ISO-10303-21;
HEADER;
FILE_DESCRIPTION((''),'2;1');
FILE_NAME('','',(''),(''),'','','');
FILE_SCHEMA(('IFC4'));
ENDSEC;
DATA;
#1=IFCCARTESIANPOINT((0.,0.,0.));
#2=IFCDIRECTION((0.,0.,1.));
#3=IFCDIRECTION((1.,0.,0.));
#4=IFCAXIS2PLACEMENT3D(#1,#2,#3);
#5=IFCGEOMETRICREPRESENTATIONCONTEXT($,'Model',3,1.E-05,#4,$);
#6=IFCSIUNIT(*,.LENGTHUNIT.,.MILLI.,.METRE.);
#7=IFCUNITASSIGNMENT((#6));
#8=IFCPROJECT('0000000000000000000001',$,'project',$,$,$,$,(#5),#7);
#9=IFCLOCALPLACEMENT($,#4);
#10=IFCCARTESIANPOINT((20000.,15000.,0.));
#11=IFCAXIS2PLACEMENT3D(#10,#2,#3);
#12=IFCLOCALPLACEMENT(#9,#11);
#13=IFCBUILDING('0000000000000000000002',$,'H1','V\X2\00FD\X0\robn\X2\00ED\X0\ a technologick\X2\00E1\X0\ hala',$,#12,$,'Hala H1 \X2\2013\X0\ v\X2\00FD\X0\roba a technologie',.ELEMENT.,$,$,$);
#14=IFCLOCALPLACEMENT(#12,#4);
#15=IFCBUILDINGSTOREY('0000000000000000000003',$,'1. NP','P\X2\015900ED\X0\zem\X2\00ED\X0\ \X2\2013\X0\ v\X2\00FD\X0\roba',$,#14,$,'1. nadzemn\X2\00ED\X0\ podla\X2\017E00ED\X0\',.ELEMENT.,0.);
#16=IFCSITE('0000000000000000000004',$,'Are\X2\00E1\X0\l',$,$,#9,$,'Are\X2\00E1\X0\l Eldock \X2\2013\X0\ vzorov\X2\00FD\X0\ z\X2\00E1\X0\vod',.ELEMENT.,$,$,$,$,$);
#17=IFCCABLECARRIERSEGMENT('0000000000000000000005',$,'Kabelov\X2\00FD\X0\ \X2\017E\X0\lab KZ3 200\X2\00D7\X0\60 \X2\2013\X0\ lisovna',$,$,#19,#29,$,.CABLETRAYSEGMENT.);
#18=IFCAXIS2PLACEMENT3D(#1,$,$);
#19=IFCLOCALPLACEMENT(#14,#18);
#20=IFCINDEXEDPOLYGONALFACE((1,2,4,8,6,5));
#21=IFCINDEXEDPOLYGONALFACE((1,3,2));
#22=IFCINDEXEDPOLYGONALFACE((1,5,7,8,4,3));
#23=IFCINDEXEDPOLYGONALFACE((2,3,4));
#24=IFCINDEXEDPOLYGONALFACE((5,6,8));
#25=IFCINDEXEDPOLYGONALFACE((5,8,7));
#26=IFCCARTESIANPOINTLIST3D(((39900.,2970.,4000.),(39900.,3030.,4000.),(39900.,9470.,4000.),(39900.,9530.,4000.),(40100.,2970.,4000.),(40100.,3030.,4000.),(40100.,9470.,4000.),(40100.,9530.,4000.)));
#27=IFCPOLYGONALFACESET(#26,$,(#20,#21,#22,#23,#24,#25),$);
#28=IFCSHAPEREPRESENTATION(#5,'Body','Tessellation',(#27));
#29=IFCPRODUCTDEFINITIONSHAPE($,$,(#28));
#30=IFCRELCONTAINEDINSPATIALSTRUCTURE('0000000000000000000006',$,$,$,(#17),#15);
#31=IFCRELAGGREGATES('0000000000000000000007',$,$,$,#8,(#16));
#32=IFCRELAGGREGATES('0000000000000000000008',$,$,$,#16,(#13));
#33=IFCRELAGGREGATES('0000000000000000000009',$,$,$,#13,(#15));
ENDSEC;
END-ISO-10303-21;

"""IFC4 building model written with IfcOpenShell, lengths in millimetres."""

from ifc_helpers import new_model, si_unit, frame, origin_with_axes, origin_2d, place, context, project, spatial, rectangle, extrude, element, save


model = new_model("IFC4")

# Units and contexts
model_context = context("Model", 3, precision=1e-05, world=origin_with_axes())
ifc_project = project(units=[si_unit("LENGTHUNIT", "METRE", prefix="MILLI")], contexts=[model_context])

# Site, building, storey
site_placement = place(None, origin_with_axes())
site = spatial("IfcSite", under=ifc_project, at=site_placement, Name="Areál", LongName="Areál Eldock – vzorový závod", CompositionType="ELEMENT")
building_placement = place(site_placement, frame((20000.0, 15000.0, 0.0), z_axis=(0.0, 0.0, 1.0), x_axis=(1.0, 0.0, 0.0)))
building = spatial("IfcBuilding", under=site, at=building_placement, Name="H1", Description="Výrobní a technologická hala", LongName="Hala H1 – výroba a technologie", CompositionType="ELEMENT")
storey_placement = place(building_placement, origin_with_axes())
storey = spatial("IfcBuildingStorey", under=building, at=storey_placement, Name="1. NP", Description="Přízemí – výroba", LongName="1. nadzemní podlaží", CompositionType="ELEMENT", Elevation=0.0)

# Cable carrier segment
cable_carrier_segment_1_placement = place(storey_placement, frame((40000.0, 9500.0, 4000.0), z_axis=(0.0, 0.0, 1.0), x_axis=(1.0, 0.0, 0.0)))
element("IfcCableCarrierSegment", 1, at=cable_carrier_segment_1_placement, inside=storey, Name="Kabelový žlab KZ3 200×60 – lisovna", PredefinedType="CABLETRAYSEGMENT", context=model_context, shape_type="SweptSolid", body=[
    extrude(rectangle(XDim=200.0, YDim=60.0, at=origin_2d()), origin_with_axes(), (0.0, -1.0, 0.0), 6500.0),
])

save(model, "model.ifc")
